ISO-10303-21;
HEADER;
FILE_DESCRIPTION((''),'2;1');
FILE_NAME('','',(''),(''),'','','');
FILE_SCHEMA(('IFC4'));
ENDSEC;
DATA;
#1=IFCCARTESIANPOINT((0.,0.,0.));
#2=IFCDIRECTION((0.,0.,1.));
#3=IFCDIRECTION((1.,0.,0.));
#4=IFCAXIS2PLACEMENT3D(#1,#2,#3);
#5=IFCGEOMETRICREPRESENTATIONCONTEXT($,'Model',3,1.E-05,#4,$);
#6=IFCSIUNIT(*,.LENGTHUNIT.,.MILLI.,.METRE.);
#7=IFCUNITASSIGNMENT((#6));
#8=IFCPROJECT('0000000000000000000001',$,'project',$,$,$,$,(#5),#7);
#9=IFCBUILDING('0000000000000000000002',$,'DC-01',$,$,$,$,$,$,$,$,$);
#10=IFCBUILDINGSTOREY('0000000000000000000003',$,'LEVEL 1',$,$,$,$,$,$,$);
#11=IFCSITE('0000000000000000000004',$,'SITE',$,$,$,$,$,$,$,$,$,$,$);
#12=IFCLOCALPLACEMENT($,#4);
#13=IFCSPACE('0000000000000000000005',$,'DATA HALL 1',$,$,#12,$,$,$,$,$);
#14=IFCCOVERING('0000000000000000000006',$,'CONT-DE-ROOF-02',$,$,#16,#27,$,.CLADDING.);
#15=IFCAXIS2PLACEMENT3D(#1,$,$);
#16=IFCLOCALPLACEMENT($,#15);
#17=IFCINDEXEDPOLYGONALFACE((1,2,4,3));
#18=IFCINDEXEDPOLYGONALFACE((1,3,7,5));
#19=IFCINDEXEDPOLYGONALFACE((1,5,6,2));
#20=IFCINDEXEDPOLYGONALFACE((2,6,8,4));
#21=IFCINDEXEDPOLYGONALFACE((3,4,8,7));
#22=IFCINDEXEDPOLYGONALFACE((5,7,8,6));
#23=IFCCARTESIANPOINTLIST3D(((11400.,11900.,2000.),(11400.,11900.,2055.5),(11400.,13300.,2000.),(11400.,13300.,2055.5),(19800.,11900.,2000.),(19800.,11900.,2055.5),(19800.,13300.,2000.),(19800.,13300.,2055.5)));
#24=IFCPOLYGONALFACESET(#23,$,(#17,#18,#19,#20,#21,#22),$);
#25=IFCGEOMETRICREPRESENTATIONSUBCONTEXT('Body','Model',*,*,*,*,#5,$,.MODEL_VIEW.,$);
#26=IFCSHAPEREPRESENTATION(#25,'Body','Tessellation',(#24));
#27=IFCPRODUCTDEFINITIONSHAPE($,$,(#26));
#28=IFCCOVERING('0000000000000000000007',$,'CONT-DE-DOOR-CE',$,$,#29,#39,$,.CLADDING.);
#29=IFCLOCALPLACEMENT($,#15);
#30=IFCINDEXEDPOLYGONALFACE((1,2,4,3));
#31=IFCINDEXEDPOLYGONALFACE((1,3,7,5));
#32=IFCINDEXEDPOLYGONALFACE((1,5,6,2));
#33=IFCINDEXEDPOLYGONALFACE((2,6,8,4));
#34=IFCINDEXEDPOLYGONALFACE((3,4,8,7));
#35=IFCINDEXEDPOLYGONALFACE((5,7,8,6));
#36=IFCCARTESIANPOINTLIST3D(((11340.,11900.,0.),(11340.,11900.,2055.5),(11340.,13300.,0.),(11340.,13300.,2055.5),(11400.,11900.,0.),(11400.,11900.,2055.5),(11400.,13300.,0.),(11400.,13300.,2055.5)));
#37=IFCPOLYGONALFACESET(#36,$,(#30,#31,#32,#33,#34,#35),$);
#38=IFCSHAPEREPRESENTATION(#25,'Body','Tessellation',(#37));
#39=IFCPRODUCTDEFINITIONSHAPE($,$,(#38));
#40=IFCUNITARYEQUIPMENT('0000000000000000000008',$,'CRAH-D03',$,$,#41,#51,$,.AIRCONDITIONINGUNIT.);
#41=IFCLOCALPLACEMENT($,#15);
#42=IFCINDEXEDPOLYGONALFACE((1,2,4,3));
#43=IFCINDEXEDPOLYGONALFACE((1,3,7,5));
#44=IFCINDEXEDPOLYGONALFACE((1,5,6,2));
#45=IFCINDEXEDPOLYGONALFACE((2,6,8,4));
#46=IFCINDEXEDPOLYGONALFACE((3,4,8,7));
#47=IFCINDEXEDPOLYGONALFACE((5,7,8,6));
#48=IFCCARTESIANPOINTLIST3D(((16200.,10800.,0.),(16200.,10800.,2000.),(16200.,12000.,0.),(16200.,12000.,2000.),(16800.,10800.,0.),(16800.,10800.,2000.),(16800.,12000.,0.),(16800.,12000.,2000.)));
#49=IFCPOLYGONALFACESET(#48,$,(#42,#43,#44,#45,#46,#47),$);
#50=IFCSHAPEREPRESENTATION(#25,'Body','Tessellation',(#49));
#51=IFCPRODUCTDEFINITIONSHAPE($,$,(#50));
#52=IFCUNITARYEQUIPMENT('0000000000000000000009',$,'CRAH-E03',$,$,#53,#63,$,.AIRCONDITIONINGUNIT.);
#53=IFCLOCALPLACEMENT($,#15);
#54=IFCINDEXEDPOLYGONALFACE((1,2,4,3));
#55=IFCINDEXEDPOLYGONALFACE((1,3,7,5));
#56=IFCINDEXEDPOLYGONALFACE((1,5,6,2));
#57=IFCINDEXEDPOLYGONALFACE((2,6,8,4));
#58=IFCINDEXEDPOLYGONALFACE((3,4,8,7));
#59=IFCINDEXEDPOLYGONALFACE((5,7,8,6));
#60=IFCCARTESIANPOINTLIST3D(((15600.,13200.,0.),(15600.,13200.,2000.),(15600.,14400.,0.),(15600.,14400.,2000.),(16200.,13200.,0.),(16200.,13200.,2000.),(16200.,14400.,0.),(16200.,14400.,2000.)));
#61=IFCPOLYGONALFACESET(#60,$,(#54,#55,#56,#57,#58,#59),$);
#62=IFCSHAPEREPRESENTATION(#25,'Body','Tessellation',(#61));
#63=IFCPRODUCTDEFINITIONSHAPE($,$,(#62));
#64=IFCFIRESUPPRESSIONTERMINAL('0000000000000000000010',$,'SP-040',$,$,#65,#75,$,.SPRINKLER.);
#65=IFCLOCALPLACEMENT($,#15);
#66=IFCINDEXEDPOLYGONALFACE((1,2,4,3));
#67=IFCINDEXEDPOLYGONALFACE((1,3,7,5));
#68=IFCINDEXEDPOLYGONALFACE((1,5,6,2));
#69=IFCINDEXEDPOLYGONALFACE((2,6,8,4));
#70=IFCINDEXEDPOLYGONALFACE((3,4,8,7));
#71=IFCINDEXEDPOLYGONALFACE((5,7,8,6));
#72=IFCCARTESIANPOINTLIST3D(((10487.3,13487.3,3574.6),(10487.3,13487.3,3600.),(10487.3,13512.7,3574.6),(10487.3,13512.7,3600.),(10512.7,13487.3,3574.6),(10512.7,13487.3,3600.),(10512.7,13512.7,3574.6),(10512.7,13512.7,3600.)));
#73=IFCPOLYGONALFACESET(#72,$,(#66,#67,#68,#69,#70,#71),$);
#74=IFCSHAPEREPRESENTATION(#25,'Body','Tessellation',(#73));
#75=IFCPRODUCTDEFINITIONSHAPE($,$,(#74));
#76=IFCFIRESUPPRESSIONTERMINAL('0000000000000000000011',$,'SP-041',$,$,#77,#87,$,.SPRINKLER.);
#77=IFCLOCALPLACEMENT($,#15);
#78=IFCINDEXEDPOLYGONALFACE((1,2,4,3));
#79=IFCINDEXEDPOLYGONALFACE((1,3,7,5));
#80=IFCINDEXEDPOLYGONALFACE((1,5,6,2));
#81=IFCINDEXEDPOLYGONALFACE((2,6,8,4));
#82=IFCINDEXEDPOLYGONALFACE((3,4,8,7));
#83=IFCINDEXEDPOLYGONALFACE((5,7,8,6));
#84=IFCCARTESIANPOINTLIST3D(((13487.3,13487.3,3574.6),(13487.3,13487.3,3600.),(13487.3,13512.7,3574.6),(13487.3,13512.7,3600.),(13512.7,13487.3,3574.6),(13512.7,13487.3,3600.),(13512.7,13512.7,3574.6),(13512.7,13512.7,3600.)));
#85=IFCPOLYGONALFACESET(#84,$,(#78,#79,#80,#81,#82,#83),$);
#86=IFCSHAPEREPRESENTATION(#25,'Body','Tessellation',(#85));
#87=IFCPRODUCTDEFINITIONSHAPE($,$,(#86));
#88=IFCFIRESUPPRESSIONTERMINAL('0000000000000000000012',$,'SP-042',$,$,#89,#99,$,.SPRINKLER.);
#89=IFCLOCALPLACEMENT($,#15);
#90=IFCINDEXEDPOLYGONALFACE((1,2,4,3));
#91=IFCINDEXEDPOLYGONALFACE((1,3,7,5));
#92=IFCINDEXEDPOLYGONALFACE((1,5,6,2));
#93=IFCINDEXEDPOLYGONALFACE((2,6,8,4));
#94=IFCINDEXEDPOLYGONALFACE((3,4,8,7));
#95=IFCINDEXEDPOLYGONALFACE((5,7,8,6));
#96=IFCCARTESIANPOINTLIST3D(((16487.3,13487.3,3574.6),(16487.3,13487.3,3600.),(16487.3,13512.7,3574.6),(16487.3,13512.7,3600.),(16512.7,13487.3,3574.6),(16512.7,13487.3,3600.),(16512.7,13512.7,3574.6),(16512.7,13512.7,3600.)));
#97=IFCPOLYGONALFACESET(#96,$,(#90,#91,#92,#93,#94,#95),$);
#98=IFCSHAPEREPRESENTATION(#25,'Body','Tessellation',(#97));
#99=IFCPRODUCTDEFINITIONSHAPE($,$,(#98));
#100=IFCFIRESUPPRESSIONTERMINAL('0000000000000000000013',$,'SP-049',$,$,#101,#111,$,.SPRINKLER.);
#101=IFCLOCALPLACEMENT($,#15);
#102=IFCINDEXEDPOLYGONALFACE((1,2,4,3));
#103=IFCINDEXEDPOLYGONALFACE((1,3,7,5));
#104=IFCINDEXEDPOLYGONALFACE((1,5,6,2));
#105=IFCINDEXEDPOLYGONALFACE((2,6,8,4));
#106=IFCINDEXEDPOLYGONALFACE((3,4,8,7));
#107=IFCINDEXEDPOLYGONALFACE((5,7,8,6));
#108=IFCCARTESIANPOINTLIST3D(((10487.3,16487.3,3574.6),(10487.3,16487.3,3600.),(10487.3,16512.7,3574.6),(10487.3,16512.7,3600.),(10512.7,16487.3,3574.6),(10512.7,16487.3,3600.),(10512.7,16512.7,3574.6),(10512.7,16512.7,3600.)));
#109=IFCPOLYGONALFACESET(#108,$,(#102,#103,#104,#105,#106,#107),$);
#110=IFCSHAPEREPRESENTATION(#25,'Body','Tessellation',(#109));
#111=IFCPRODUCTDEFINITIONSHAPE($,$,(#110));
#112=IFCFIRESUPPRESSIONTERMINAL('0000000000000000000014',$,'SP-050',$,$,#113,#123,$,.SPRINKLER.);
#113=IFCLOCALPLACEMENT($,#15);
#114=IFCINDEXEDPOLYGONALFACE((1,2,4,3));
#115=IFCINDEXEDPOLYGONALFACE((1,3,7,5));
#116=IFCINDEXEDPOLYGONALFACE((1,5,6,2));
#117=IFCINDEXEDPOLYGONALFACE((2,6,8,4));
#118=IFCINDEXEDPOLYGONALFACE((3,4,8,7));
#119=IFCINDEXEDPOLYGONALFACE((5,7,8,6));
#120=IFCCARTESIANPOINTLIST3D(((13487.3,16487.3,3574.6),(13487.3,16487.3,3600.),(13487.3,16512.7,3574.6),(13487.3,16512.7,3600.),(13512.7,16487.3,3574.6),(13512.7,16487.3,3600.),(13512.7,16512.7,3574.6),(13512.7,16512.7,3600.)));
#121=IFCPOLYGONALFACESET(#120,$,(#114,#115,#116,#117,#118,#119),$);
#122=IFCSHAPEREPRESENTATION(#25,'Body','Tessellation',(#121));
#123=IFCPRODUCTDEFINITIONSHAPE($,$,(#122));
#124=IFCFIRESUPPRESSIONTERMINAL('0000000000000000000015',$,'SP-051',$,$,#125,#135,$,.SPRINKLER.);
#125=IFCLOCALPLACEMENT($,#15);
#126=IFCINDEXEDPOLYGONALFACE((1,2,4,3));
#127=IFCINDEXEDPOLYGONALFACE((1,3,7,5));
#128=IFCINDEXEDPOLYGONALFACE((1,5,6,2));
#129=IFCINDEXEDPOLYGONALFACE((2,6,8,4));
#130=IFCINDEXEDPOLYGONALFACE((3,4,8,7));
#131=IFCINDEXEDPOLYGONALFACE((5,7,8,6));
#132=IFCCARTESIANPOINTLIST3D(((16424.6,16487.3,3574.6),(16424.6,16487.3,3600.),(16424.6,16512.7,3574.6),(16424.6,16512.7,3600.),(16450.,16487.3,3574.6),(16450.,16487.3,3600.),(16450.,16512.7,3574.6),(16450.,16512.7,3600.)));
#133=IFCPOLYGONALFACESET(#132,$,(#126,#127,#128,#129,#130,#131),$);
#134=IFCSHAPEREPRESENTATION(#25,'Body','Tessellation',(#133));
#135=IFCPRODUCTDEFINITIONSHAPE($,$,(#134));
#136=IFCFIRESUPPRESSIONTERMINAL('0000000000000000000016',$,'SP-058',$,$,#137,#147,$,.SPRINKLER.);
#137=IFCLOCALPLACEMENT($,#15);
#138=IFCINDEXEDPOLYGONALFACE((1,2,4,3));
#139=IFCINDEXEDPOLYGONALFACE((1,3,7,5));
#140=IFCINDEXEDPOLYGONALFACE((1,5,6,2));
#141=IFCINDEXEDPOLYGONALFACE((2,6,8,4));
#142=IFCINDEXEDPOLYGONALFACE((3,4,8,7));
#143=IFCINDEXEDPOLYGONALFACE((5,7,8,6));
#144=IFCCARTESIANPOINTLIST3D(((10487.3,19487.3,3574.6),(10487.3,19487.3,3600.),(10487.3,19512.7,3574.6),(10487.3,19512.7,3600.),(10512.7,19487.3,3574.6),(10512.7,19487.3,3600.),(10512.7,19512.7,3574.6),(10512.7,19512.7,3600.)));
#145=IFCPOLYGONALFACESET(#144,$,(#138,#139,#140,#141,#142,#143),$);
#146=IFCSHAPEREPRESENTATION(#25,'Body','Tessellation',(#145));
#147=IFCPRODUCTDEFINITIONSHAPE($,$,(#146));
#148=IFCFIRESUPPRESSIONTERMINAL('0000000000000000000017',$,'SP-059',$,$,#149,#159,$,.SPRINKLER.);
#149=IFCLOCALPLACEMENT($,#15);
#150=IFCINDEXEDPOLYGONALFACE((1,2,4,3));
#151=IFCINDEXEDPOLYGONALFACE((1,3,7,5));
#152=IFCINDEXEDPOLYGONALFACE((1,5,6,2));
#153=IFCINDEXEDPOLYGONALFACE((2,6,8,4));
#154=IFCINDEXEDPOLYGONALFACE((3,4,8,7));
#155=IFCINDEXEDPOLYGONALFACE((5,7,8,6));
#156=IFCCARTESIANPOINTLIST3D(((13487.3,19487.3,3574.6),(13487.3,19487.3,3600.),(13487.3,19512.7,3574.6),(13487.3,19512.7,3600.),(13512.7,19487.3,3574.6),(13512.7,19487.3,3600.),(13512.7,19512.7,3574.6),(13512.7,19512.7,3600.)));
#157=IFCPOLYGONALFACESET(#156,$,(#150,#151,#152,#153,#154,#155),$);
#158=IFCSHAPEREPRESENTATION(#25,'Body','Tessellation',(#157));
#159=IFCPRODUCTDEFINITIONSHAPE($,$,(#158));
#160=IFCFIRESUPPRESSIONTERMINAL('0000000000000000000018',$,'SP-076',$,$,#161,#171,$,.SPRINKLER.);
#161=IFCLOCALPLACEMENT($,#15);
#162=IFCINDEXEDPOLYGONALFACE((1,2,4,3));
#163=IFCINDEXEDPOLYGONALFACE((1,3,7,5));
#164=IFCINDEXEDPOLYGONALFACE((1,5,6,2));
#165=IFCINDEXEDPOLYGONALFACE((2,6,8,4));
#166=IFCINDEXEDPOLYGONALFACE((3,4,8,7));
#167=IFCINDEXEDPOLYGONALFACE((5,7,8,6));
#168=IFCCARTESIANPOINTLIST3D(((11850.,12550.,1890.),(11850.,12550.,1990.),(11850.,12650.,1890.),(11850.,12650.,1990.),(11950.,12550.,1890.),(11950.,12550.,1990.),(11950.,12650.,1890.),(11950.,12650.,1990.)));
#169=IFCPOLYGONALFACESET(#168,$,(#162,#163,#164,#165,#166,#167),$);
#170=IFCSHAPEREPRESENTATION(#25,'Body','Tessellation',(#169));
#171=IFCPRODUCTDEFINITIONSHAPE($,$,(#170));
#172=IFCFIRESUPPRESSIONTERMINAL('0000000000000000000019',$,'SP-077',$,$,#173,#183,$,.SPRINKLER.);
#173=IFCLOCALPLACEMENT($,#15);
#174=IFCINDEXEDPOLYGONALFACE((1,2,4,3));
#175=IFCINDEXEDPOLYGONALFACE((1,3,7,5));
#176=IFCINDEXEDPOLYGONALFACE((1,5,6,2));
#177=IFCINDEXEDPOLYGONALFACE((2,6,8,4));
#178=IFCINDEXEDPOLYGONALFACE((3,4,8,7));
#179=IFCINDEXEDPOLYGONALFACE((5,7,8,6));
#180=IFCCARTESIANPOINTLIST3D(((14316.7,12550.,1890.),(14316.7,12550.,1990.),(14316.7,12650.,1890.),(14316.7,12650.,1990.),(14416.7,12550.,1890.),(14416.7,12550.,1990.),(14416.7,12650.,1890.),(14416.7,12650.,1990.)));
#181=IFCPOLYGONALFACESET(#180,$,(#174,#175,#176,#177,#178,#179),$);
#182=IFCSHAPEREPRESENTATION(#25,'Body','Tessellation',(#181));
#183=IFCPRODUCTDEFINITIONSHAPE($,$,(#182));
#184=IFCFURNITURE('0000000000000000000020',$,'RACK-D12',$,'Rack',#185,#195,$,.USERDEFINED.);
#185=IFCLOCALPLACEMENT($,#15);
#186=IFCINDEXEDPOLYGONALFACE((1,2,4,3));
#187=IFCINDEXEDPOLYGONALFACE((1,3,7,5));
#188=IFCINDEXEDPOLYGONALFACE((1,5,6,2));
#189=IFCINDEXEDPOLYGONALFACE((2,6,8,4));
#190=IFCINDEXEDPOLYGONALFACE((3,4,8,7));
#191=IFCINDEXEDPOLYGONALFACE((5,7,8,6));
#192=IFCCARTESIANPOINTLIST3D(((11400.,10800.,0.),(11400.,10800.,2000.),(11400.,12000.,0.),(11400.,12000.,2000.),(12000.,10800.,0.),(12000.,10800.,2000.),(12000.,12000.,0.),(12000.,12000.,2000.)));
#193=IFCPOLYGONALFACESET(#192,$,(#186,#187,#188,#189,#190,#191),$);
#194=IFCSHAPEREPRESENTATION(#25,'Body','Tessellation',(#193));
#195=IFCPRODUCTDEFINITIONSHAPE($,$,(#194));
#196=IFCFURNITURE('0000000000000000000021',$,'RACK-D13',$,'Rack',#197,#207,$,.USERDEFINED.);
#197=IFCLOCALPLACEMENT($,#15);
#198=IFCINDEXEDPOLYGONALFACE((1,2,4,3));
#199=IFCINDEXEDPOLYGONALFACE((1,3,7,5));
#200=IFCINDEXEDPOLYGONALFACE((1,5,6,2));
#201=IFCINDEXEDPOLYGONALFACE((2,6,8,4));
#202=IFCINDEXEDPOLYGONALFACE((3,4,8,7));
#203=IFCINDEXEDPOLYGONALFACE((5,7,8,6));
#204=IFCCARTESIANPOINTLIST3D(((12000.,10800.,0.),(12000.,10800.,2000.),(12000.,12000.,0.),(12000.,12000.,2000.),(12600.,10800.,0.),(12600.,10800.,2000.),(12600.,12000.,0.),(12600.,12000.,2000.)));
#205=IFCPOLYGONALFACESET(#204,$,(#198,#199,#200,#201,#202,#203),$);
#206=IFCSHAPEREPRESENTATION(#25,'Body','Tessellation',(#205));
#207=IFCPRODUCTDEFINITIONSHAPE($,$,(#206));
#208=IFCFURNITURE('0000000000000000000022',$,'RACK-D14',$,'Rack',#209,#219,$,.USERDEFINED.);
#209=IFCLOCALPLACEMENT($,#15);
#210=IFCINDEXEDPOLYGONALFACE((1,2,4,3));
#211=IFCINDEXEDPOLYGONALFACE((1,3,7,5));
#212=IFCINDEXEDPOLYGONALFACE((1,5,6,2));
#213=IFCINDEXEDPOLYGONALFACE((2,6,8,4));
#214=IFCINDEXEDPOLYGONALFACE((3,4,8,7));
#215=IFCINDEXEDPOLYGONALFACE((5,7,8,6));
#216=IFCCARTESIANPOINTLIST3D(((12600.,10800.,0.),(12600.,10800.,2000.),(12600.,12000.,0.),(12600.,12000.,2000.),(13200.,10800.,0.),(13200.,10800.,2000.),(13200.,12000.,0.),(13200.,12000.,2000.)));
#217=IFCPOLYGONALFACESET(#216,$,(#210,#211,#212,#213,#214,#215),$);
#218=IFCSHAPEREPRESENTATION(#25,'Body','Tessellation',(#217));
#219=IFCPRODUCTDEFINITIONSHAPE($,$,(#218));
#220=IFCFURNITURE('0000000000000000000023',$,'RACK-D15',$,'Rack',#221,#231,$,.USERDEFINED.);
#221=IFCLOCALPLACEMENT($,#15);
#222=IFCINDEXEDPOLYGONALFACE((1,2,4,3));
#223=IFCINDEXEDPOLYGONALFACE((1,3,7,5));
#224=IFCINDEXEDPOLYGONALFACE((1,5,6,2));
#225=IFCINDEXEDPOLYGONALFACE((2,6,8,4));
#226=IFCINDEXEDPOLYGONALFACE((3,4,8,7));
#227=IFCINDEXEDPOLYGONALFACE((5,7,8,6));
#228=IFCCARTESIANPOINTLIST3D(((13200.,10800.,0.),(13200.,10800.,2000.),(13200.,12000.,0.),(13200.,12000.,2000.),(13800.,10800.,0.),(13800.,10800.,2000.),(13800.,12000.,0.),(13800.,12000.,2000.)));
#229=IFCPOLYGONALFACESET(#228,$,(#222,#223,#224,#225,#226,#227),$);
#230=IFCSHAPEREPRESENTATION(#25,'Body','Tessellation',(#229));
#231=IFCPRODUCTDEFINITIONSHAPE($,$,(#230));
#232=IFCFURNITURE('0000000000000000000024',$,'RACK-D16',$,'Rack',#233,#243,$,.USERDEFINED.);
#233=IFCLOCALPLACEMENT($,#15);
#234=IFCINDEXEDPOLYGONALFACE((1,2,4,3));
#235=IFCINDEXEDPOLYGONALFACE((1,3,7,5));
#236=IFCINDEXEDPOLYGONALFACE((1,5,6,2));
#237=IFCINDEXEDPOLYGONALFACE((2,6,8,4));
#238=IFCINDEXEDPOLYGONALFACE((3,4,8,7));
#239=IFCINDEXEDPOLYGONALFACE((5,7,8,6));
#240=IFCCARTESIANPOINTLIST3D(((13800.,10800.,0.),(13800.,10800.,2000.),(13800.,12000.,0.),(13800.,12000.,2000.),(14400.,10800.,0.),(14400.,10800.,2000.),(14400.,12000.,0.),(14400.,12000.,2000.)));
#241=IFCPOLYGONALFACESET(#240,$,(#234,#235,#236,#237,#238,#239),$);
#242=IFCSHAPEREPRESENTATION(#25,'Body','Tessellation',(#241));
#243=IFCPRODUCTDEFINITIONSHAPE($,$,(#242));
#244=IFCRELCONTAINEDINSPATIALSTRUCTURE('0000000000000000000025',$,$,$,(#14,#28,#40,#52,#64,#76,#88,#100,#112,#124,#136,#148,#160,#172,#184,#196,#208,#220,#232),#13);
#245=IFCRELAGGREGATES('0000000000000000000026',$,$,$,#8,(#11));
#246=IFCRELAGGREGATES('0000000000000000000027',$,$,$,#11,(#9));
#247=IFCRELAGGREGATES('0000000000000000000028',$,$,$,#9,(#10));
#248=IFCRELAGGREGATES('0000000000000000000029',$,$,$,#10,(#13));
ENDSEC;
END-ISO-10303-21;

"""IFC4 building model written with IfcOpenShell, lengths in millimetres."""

from ifc_helpers import new_model, si_unit, frame, origin, origin_with_axes, place, context, subcontext, project, spatial, polyline, outline, extrude, element, save


model = new_model("IFC4")

# Units and contexts
model_context = context("Model", 3, precision=1e-05, world=origin_with_axes())
body_context = subcontext(model_context, "Body", "Model", "MODEL_VIEW")
ifc_project = project(units=[si_unit("LENGTHUNIT", "METRE", prefix="MILLI")], contexts=[model_context])

# Site, building, storey, space
site = spatial("IfcSite", under=ifc_project, Name="SITE")
building = spatial("IfcBuilding", under=site, Name="DC-01")
storey = spatial("IfcBuildingStorey", under=building, Name="LEVEL 1")
space_placement = place(None, origin_with_axes())
space = spatial("IfcSpace", under=storey, at=space_placement, Name="DATA HALL 1")

# Coverings
covering_1_placement = place(space_placement, frame((11400.0, 11900.0, 2000.0), z_axis=(0.0, 0.0, 1.0), x_axis=(1.0, 0.0, 0.0)))
element("IfcCovering", 1, at=covering_1_placement, inside=space, Name="CONT-DE-ROOF-02", PredefinedType="CLADDING", context=body_context, shape_type="SweptSolid", body=[
    extrude(outline(polyline([(0.0, 0.0), (8400.0, 0.0), (8400.0, 1400.0), (0.0, 1400.0), (0.0, 0.0)])), origin(), (0.0, 0.0, 1.0), 55.5),
])
covering_2_placement = place(space_placement, frame((11340.0, 11900.0, 0.0), z_axis=(0.0, 0.0, 1.0), x_axis=(1.0, 0.0, 0.0)))
element("IfcCovering", 2, at=covering_2_placement, inside=space, Name="CONT-DE-DOOR-CE", PredefinedType="CLADDING", context=body_context, shape_type="SweptSolid", body=[
    extrude(outline(polyline([(0.0, 0.0), (60.0, 0.0), (60.0, 1400.0), (0.0, 1400.0), (0.0, 0.0)])), origin(), (0.0, 0.0, 1.0), 2055.5),
])

# Unitary equipment
for number, where, z_axis, x_axis, name in (
    (3, (16200.0, 10800.0, 0.0), (0.0, 0.0, 1.0), (1.0, 0.0, 0.0), "CRAH-D03"),
    (4, (16200.0, 14400.0, 0.0), (0.0, 0.0, 1.0), (-1.0, 0.0, 0.0), "CRAH-E03"),
):
    element("IfcUnitaryEquipment", number, at=place(space_placement, frame(where, z_axis=z_axis, x_axis=x_axis)), inside=space, Name=name, PredefinedType="AIRCONDITIONINGUNIT", context=body_context, shape_type="SweptSolid", body=[
        extrude(outline(polyline([(0.0, 0.0), (600.0, 0.0), (600.0, 1200.0), (0.0, 1200.0), (0.0, 0.0)])), origin(), (0.0, 0.0, 1.0), 2000.0),
    ])

# Fire suppression terminals
for number, where, z_axis, x_axis, name in (
    (5, (10487.3, 13487.3, 3574.6), (0.0, 0.0, 1.0), (1.0, 0.0, 0.0), "SP-040"),
    (6, (13487.3, 13487.3, 3574.6), (0.0, 0.0, 1.0), (1.0, 0.0, 0.0), "SP-041"),
    (7, (16487.3, 13487.3, 3574.6), (0.0, 0.0, 1.0), (1.0, 0.0, 0.0), "SP-042"),
    (8, (10487.3, 16487.3, 3574.6), (0.0, 0.0, 1.0), (1.0, 0.0, 0.0), "SP-049"),
    (9, (13487.3, 16487.3, 3574.6), (0.0, 0.0, 1.0), (1.0, 0.0, 0.0), "SP-050"),
    (10, (16424.6, 16487.3, 3574.6), (0.0, 0.0, 1.0), (1.0, 0.0, 0.0), "SP-051"),
    (11, (10487.3, 19487.3, 3574.6), (0.0, 0.0, 1.0), (1.0, 0.0, 0.0), "SP-058"),
    (12, (13487.3, 19487.3, 3574.6), (0.0, 0.0, 1.0), (1.0, 0.0, 0.0), "SP-059"),
):
    element("IfcFireSuppressionTerminal", number, at=place(space_placement, frame(where, z_axis=z_axis, x_axis=x_axis)), inside=space, Name=name, PredefinedType="SPRINKLER", context=body_context, shape_type="SweptSolid", body=[
        extrude(outline(polyline([(0.0, 0.0), (25.4, 0.0), (25.4, 25.4), (0.0, 25.4), (0.0, 0.0)])), origin(), (0.0, 0.0, 1.0), 25.4),
    ])
for number, where, z_axis, x_axis, name in (
    (13, (11850.0, 12550.0, 1890.0), (0.0, 0.0, 1.0), (1.0, 0.0, 0.0), "SP-076"),
    (14, (14316.7, 12550.0, 1890.0), (0.0, 0.0, 1.0), (1.0, 0.0, 0.0), "SP-077"),
):
    element("IfcFireSuppressionTerminal", number, at=place(space_placement, frame(where, z_axis=z_axis, x_axis=x_axis)), inside=space, Name=name, PredefinedType="SPRINKLER", context=body_context, shape_type="SweptSolid", body=[
        extrude(outline(polyline([(0.0, 0.0), (100.0, 0.0), (100.0, 100.0), (0.0, 100.0), (0.0, 0.0)])), origin(), (0.0, 0.0, 1.0), 100.0),
    ])

# Furniture
for number, where, z_axis, x_axis, name in (
    (15, (11400.0, 10800.0, 0.0), (0.0, 0.0, 1.0), (1.0, 0.0, 0.0), "RACK-D12"),
    (16, (12000.0, 10800.0, 0.0), (0.0, 0.0, 1.0), (1.0, 0.0, 0.0), "RACK-D13"),
    (17, (12600.0, 10800.0, 0.0), (0.0, 0.0, 1.0), (1.0, 0.0, 0.0), "RACK-D14"),
    (18, (13200.0, 10800.0, 0.0), (0.0, 0.0, 1.0), (1.0, 0.0, 0.0), "RACK-D15"),
    (19, (13800.0, 10800.0, 0.0), (0.0, 0.0, 1.0), (1.0, 0.0, 0.0), "RACK-D16"),
):
    element("IfcFurniture", number, at=place(space_placement, frame(where, z_axis=z_axis, x_axis=x_axis)), inside=space, Name=name, ObjectType="Rack", PredefinedType="USERDEFINED", context=body_context, shape_type="SweptSolid", body=[
        extrude(outline(polyline([(0.0, 0.0), (600.0, 0.0), (600.0, 1200.0), (0.0, 1200.0), (0.0, 0.0)])), origin(), (0.0, 0.0, 1.0), 2000.0),
    ])

save(model, "model.ifc")
